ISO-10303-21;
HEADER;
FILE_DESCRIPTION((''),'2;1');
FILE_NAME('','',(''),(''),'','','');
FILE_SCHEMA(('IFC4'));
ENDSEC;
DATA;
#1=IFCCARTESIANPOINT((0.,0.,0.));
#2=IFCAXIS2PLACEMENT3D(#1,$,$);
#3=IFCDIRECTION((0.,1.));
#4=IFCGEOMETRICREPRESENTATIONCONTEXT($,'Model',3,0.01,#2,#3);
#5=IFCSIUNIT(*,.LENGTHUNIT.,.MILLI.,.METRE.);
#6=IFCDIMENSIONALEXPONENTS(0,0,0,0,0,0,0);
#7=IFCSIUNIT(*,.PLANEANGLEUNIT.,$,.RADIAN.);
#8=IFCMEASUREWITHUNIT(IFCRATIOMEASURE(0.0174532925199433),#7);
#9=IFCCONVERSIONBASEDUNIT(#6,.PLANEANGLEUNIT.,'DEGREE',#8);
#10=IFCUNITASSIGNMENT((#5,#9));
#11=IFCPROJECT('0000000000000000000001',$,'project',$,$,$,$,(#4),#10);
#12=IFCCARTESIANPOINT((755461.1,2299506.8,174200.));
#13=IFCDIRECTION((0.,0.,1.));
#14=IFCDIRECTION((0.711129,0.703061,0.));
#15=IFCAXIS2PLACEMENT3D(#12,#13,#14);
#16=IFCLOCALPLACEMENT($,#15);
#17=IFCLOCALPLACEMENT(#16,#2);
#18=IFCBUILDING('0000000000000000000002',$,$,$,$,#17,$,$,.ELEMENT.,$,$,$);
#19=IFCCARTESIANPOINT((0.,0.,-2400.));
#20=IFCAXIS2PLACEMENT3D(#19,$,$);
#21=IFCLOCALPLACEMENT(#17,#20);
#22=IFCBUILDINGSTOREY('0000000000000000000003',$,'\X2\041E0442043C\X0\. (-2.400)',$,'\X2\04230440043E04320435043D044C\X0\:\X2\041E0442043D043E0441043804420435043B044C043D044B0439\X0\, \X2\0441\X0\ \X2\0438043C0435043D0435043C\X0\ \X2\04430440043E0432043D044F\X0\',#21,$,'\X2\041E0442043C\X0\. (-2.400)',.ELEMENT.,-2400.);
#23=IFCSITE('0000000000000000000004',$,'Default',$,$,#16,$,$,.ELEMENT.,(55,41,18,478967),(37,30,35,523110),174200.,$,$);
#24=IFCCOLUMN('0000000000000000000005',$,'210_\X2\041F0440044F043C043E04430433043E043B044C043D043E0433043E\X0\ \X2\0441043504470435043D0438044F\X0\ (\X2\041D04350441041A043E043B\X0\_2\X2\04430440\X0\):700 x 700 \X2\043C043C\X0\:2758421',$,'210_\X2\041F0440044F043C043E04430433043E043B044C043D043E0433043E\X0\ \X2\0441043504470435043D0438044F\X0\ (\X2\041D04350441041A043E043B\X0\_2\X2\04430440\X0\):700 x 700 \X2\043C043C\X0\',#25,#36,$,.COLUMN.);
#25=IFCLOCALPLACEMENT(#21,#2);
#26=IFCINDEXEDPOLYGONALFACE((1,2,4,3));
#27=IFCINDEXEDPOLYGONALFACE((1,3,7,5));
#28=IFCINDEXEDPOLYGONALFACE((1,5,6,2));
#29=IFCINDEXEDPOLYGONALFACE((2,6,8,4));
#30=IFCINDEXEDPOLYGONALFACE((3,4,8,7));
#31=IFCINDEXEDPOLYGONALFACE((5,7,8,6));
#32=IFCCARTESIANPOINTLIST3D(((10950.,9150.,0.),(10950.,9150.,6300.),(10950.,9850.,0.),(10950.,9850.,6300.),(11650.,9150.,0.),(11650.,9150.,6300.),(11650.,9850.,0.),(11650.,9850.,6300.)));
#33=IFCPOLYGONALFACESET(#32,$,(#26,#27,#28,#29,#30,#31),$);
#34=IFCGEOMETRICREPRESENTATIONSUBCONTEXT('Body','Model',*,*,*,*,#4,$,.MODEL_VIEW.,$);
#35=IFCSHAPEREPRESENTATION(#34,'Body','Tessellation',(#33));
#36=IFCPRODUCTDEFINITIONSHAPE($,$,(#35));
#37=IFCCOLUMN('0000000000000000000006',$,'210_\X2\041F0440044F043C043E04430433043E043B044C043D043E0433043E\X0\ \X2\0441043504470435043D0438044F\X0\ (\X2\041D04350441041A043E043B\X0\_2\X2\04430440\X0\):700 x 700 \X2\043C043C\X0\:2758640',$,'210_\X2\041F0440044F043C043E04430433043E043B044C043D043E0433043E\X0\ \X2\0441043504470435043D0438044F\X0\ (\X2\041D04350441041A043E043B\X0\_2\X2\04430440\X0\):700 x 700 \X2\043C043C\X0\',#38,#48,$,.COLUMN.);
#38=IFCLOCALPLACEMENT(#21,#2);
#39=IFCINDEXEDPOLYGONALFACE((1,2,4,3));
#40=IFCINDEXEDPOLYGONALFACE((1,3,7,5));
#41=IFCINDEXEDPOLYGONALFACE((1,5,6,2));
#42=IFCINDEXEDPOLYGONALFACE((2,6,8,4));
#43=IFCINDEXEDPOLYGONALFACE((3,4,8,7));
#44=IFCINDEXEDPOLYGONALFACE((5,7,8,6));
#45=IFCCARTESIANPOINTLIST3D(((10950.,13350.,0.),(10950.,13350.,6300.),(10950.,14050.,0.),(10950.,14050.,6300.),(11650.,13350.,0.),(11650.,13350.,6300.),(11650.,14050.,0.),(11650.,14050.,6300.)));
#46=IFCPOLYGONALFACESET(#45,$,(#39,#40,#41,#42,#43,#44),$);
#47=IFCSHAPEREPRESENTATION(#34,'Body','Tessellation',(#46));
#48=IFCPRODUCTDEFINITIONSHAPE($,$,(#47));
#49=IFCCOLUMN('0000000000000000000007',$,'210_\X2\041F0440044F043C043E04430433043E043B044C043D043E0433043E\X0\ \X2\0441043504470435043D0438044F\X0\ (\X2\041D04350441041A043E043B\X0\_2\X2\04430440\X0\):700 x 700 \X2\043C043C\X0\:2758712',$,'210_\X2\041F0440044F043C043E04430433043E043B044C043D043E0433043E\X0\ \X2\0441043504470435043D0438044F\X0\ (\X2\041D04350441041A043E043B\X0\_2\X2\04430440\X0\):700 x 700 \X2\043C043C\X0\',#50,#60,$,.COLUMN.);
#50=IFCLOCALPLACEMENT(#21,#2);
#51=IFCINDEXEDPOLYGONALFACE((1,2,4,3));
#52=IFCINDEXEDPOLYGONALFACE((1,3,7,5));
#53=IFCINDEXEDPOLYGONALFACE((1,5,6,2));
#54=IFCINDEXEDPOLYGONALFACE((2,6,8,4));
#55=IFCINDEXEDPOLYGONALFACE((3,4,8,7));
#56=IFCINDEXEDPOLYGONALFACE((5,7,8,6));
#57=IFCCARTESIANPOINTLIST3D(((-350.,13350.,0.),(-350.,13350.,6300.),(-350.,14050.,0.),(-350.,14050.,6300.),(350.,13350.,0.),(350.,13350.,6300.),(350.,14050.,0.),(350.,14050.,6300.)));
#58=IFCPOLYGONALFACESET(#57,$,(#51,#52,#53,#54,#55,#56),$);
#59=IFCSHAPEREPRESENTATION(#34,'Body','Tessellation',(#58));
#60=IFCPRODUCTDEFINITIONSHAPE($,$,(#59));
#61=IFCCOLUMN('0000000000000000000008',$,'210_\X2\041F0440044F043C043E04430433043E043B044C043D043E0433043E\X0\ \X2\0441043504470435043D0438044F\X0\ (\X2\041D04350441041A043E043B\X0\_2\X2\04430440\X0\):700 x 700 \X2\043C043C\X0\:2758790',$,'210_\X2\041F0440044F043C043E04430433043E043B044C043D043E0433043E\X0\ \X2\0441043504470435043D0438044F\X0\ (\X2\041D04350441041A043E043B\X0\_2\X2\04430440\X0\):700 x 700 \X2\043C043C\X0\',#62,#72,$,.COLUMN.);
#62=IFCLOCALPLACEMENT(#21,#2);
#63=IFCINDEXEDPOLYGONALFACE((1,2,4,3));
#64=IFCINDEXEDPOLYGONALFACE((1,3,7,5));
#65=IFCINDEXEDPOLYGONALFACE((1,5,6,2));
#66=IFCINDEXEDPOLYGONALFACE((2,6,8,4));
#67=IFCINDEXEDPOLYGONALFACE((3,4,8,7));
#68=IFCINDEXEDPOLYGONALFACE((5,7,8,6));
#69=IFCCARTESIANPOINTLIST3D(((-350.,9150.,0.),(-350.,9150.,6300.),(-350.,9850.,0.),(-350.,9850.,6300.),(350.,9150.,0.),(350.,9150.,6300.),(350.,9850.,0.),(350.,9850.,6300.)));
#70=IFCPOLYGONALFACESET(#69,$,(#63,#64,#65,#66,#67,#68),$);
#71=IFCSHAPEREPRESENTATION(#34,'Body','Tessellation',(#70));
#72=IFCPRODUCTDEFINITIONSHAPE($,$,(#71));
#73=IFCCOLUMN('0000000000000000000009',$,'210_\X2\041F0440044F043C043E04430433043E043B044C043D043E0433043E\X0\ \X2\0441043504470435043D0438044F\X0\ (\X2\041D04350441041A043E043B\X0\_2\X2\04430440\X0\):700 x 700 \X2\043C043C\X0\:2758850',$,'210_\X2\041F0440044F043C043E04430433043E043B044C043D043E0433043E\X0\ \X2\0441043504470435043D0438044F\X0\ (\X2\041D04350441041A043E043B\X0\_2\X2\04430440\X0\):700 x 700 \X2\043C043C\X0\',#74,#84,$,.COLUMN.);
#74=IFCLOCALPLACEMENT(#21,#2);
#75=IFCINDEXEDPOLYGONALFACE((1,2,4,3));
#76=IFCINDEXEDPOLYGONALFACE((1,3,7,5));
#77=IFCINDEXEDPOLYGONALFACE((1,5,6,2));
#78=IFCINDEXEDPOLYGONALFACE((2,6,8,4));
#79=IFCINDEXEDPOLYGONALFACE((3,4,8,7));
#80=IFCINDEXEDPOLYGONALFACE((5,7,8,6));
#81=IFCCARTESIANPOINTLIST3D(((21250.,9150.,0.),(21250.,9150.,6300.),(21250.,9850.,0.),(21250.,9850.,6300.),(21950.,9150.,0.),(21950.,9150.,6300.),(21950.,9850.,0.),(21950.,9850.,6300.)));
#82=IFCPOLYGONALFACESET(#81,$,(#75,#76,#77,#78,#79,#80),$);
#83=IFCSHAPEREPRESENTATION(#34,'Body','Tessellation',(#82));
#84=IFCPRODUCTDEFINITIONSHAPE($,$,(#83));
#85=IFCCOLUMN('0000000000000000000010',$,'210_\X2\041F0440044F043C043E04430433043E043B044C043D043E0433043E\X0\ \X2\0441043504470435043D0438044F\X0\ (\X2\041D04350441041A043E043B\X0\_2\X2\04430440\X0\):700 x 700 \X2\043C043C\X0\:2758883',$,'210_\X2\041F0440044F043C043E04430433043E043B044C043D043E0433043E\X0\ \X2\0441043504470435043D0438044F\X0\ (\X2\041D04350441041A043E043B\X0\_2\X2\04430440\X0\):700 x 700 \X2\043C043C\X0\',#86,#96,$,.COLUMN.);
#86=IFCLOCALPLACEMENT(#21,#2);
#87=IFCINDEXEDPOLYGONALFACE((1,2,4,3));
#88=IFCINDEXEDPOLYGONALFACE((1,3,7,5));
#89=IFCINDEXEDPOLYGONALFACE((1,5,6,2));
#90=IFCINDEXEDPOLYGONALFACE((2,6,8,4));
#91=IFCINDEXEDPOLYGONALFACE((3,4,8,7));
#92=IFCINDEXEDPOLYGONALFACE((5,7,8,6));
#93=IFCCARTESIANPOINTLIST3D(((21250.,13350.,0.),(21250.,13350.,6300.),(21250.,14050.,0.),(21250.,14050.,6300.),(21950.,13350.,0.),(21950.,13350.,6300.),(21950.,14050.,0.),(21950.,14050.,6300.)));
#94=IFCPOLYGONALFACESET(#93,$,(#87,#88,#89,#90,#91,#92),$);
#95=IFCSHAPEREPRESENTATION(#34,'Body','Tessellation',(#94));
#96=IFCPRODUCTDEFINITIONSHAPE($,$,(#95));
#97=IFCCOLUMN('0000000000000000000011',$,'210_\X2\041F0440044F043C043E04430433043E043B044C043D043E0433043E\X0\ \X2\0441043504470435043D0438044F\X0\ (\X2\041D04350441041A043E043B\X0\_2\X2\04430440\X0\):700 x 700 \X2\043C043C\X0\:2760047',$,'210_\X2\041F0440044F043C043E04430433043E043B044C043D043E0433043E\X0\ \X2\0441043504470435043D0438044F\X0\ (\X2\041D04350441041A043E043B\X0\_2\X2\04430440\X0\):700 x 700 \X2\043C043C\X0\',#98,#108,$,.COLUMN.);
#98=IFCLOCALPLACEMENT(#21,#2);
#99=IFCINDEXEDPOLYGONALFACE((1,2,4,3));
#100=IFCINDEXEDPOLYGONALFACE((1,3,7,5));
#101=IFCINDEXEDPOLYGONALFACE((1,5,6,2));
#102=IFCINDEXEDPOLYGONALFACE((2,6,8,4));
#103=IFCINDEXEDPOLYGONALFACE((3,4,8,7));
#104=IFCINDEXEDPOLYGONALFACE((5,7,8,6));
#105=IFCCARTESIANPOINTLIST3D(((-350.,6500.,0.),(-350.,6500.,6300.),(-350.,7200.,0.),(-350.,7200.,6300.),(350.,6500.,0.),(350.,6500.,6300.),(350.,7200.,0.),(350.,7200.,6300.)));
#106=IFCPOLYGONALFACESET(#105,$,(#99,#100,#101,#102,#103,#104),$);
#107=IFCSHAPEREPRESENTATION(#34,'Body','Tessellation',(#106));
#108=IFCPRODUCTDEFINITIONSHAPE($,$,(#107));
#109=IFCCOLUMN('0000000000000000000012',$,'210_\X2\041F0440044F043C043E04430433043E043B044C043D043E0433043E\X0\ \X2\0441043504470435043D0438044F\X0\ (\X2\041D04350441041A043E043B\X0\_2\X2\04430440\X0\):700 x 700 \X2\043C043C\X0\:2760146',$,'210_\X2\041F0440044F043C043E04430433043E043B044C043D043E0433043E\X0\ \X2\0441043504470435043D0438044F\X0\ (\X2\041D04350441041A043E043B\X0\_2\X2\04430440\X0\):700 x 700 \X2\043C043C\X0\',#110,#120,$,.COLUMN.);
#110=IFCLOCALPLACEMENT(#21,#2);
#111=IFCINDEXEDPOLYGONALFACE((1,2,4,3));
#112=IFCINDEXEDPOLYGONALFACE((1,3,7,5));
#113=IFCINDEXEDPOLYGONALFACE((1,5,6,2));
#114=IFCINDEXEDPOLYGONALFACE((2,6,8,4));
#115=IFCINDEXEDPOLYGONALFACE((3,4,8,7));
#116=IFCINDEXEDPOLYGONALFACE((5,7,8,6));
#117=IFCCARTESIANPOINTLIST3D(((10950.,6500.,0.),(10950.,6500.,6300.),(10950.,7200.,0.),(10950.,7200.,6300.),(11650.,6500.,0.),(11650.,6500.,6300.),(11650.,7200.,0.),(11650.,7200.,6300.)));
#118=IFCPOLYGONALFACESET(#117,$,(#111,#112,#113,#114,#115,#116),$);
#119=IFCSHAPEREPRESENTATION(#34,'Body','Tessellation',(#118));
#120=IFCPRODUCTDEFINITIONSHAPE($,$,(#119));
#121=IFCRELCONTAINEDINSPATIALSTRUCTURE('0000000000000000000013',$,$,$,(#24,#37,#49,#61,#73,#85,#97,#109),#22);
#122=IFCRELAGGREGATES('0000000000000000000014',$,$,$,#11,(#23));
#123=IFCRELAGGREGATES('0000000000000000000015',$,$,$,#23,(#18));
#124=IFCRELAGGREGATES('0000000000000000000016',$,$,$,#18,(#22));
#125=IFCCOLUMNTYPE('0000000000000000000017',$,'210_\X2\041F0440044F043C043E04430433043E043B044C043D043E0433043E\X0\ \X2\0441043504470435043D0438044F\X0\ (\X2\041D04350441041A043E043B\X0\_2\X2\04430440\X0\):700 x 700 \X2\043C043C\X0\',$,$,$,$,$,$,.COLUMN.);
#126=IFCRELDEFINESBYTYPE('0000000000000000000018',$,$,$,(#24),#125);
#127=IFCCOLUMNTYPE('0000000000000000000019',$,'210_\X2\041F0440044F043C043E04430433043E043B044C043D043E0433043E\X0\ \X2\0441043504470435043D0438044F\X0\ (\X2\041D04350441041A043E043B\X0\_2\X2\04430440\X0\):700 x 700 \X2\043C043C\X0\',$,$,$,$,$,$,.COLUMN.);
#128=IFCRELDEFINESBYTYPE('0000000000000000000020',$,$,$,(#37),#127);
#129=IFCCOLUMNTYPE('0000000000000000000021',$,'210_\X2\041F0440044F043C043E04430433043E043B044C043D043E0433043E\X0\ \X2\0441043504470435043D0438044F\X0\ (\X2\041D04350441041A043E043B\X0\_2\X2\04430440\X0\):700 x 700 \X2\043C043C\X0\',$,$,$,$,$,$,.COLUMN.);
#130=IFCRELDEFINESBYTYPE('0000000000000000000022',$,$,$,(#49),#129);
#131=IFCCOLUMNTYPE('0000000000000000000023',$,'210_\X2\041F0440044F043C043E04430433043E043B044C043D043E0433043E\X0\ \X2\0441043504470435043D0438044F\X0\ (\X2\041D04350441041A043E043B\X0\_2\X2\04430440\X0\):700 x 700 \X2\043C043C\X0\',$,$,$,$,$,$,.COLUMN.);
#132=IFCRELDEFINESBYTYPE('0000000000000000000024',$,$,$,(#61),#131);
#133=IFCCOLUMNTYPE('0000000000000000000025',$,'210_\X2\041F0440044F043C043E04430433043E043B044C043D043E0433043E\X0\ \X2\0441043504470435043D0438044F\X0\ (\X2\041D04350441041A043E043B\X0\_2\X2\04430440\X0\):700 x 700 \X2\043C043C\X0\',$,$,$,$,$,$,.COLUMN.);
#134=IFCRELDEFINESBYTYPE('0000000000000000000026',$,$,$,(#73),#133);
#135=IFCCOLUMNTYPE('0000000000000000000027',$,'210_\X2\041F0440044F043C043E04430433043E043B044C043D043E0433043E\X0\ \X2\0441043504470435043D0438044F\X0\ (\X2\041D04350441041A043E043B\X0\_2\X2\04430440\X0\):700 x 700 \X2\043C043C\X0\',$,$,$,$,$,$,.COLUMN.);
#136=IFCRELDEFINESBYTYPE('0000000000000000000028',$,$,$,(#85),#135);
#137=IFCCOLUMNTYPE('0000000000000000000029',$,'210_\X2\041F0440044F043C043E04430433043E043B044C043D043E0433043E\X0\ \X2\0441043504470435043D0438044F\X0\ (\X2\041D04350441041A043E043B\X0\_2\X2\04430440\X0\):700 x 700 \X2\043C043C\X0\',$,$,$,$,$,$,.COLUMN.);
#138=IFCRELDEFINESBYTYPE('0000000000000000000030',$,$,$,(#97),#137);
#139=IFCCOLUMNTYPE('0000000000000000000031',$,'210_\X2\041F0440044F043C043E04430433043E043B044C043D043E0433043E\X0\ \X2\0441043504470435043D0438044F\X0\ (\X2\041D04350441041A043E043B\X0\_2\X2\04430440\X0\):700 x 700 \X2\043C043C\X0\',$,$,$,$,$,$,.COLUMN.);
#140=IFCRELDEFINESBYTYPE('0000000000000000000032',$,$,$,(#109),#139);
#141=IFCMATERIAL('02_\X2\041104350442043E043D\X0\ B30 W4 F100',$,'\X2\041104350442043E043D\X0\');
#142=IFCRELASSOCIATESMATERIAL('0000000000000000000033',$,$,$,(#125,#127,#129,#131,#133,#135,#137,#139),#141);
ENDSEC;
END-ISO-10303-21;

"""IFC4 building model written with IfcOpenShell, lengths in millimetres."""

from ifc_helpers import new_model, entity, si_unit, converted_unit, direction, frame, origin, place, context, subcontext, project, spatial, indexed_curve, outline, extrude, source, transform, mapped, material, type_object, type_shapes, element, save


model = new_model("IFC4")

# Units and contexts
model_context = context("Model", 3, precision=0.01, world=origin(), true_north=direction((0.0, 1.0)))
body_context = subcontext(model_context, "Body", "Model", "MODEL_VIEW")
ifc_project = project(units=[si_unit("LENGTHUNIT", "METRE", prefix="MILLI"), converted_unit("PLANEANGLEUNIT", "DEGREE", entity("IfcRatioMeasure", 0.0174532925199433), si_unit("PLANEANGLEUNIT", "RADIAN"), dimensions=[0, 0, 0, 0, 0, 0, 0])], contexts=[model_context])

# Site, building, storey
site_placement = place(None, frame((755461.1, 2299506.8, 174200.0), z_axis=(0.0, 0.0, 1.0), x_axis=(0.711129, 0.703061, 0.0)))
site = spatial("IfcSite", under=ifc_project, at=site_placement, Name="Default", CompositionType="ELEMENT", RefLatitude=(55, 41, 18, 478967), RefLongitude=(37, 30, 35, 523110), RefElevation=174200.0)
building_placement = place(site_placement, origin())
building = spatial("IfcBuilding", under=site, at=building_placement, CompositionType="ELEMENT")
storey_placement = place(building_placement, frame((0.0, 0.0, -2400.0)))
storey = spatial("IfcBuildingStorey", under=building, at=storey_placement, Name="Отм. (-2.400)", ObjectType="Уровень:Относительный, с именем уровня", LongName="Отм. (-2.400)", CompositionType="ELEMENT", Elevation=-2400.0)

# Columns
ifc_material_1 = material(Name="02_Бетон B30 W4 F100", Category="Бетон")
column_type_1 = type_object("IfcColumnType", Name="210_Прямоугольного сечения (НесКол_2ур):700 x 700 мм", PredefinedType="COLUMN", material=ifc_material_1)
shared_shape_1 = source(origin(), body_context, "Body", "SweptSolid", [
    extrude(outline(indexed_curve([(-350.0, -350.0), (350.0, -350.0), (350.0, 350.0), (-350.0, 350.0), (-350.0, -350.0)], self_intersect=False)), frame((11300.0, 9500.0, -2400.0), z_axis=(0.0, 0.0, 1.0), x_axis=(0.0, -1.0, 0.0)), (0.0, 0.0, 1.0), 6300.0),
])
type_shapes(column_type_1, [shared_shape_1])
column_1_placement = place(storey_placement, frame((0.0, 0.0, 2400.0)))
element("IfcColumn", 1, at=column_1_placement, inside=storey, type_object=column_type_1, Name="210_Прямоугольного сечения (НесКол_2ур):700 x 700 мм:2758421", ObjectType="210_Прямоугольного сечения (НесКол_2ур):700 x 700 мм", PredefinedType="COLUMN", context=body_context, shape_type="MappedRepresentation", body=[
    mapped(shared_shape_1, transform((0.0, 0.0, 0.0), scale=1.0)),
])
column_type_2 = type_object("IfcColumnType", Name="210_Прямоугольного сечения (НесКол_2ур):700 x 700 мм", PredefinedType="COLUMN", material=ifc_material_1)
shared_shape_2 = source(origin(), body_context, "Body", "SweptSolid", [
    extrude(outline(indexed_curve([(-350.0, -350.0), (350.0, -350.0), (350.0, 350.0), (-350.0, 350.0), (-350.0, -350.0)], self_intersect=False)), frame((11300.0, 13700.0, -2400.0), z_axis=(0.0, 0.0, 1.0), x_axis=(0.0, -1.0, 0.0)), (0.0, 0.0, 1.0), 6300.0),
])
type_shapes(column_type_2, [shared_shape_2])
column_2_placement = place(storey_placement, frame((0.0, 0.0, 2400.0)))
element("IfcColumn", 2, at=column_2_placement, inside=storey, type_object=column_type_2, Name="210_Прямоугольного сечения (НесКол_2ур):700 x 700 мм:2758640", ObjectType="210_Прямоугольного сечения (НесКол_2ур):700 x 700 мм", PredefinedType="COLUMN", context=body_context, shape_type="MappedRepresentation", body=[
    mapped(shared_shape_2, transform((0.0, 0.0, 0.0), scale=1.0)),
])
column_type_3 = type_object("IfcColumnType", Name="210_Прямоугольного сечения (НесКол_2ур):700 x 700 мм", PredefinedType="COLUMN", material=ifc_material_1)
shared_shape_3 = source(origin(), body_context, "Body", "SweptSolid", [
    extrude(outline(indexed_curve([(-350.0, -350.0), (350.0, -350.0), (350.0, 350.0), (-350.0, 350.0), (-350.0, -350.0)], self_intersect=False)), frame((0.0, 13700.0, -2400.0), z_axis=(0.0, 0.0, 1.0), x_axis=(0.0, -1.0, 0.0)), (0.0, 0.0, 1.0), 6300.0),
])
type_shapes(column_type_3, [shared_shape_3])
column_3_placement = place(storey_placement, frame((0.0, 0.0, 2400.0)))
element("IfcColumn", 3, at=column_3_placement, inside=storey, type_object=column_type_3, Name="210_Прямоугольного сечения (НесКол_2ур):700 x 700 мм:2758712", ObjectType="210_Прямоугольного сечения (НесКол_2ур):700 x 700 мм", PredefinedType="COLUMN", context=body_context, shape_type="MappedRepresentation", body=[
    mapped(shared_shape_3, transform((0.0, 0.0, 0.0), scale=1.0)),
])
column_type_4 = type_object("IfcColumnType", Name="210_Прямоугольного сечения (НесКол_2ур):700 x 700 мм", PredefinedType="COLUMN", material=ifc_material_1)
shared_shape_4 = source(origin(), body_context, "Body", "SweptSolid", [
    extrude(outline(indexed_curve([(-350.0, -350.0), (350.0, -350.0), (350.0, 350.0), (-350.0, 350.0), (-350.0, -350.0)], self_intersect=False)), frame((0.0, 9500.0, -2400.0), z_axis=(0.0, 0.0, 1.0), x_axis=(0.0, -1.0, 0.0)), (0.0, 0.0, 1.0), 6300.0),
])
type_shapes(column_type_4, [shared_shape_4])
column_4_placement = place(storey_placement, frame((0.0, 0.0, 2400.0)))
element("IfcColumn", 4, at=column_4_placement, inside=storey, type_object=column_type_4, Name="210_Прямоугольного сечения (НесКол_2ур):700 x 700 мм:2758790", ObjectType="210_Прямоугольного сечения (НесКол_2ур):700 x 700 мм", PredefinedType="COLUMN", context=body_context, shape_type="MappedRepresentation", body=[
    mapped(shared_shape_4, transform((0.0, 0.0, 0.0), scale=1.0)),
])
column_type_5 = type_object("IfcColumnType", Name="210_Прямоугольного сечения (НесКол_2ур):700 x 700 мм", PredefinedType="COLUMN", material=ifc_material_1)
shared_shape_5 = source(origin(), body_context, "Body", "SweptSolid", [
    extrude(outline(indexed_curve([(-350.0, -350.0), (350.0, -350.0), (350.0, 350.0), (-350.0, 350.0), (-350.0, -350.0)], self_intersect=False)), frame((21600.0, 9500.0, -2400.0), z_axis=(0.0, 0.0, 1.0), x_axis=(0.0, -1.0, 0.0)), (0.0, 0.0, 1.0), 6300.0),
])
type_shapes(column_type_5, [shared_shape_5])
column_5_placement = place(storey_placement, frame((0.0, 0.0, 2400.0)))
element("IfcColumn", 5, at=column_5_placement, inside=storey, type_object=column_type_5, Name="210_Прямоугольного сечения (НесКол_2ур):700 x 700 мм:2758850", ObjectType="210_Прямоугольного сечения (НесКол_2ур):700 x 700 мм", PredefinedType="COLUMN", context=body_context, shape_type="MappedRepresentation", body=[
    mapped(shared_shape_5, transform((0.0, 0.0, 0.0), scale=1.0)),
])
column_type_6 = type_object("IfcColumnType", Name="210_Прямоугольного сечения (НесКол_2ур):700 x 700 мм", PredefinedType="COLUMN", material=ifc_material_1)
shared_shape_6 = source(origin(), body_context, "Body", "SweptSolid", [
    extrude(outline(indexed_curve([(-350.0, -350.0), (350.0, -350.0), (350.0, 350.0), (-350.0, 350.0), (-350.0, -350.0)], self_intersect=False)), frame((21600.0, 13700.0, -2400.0), z_axis=(0.0, 0.0, 1.0), x_axis=(0.0, -1.0, 0.0)), (0.0, 0.0, 1.0), 6300.0),
])
type_shapes(column_type_6, [shared_shape_6])
column_6_placement = place(storey_placement, frame((0.0, 0.0, 2400.0)))
element("IfcColumn", 6, at=column_6_placement, inside=storey, type_object=column_type_6, Name="210_Прямоугольного сечения (НесКол_2ур):700 x 700 мм:2758883", ObjectType="210_Прямоугольного сечения (НесКол_2ур):700 x 700 мм", PredefinedType="COLUMN", context=body_context, shape_type="MappedRepresentation", body=[
    mapped(shared_shape_6, transform((0.0, 0.0, 0.0), scale=1.0)),
])
column_type_7 = type_object("IfcColumnType", Name="210_Прямоугольного сечения (НесКол_2ур):700 x 700 мм", PredefinedType="COLUMN", material=ifc_material_1)
shared_shape_7 = source(origin(), body_context, "Body", "SweptSolid", [
    extrude(outline(indexed_curve([(-350.0, -350.0), (350.0, -350.0), (350.0, 350.0), (-350.0, 350.0), (-350.0, -350.0)], self_intersect=False)), frame((0.0, 6850.0, -2400.0), z_axis=(0.0, 0.0, 1.0), x_axis=(0.0, -1.0, 0.0)), (0.0, 0.0, 1.0), 6300.0),
])
type_shapes(column_type_7, [shared_shape_7])
column_7_placement = place(storey_placement, frame((0.0, 0.0, 2400.0)))
element("IfcColumn", 7, at=column_7_placement, inside=storey, type_object=column_type_7, Name="210_Прямоугольного сечения (НесКол_2ур):700 x 700 мм:2760047", ObjectType="210_Прямоугольного сечения (НесКол_2ур):700 x 700 мм", PredefinedType="COLUMN", context=body_context, shape_type="MappedRepresentation", body=[
    mapped(shared_shape_7, transform((0.0, 0.0, 0.0), scale=1.0)),
])
column_type_8 = type_object("IfcColumnType", Name="210_Прямоугольного сечения (НесКол_2ур):700 x 700 мм", PredefinedType="COLUMN", material=ifc_material_1)
shared_shape_8 = source(origin(), body_context, "Body", "SweptSolid", [
    extrude(outline(indexed_curve([(-350.0, -350.0), (350.0, -350.0), (350.0, 350.0), (-350.0, 350.0), (-350.0, -350.0)], self_intersect=False)), frame((11300.0, 6850.0, -2400.0), z_axis=(0.0, 0.0, 1.0), x_axis=(0.0, -1.0, 0.0)), (0.0, 0.0, 1.0), 6300.0),
])
type_shapes(column_type_8, [shared_shape_8])
column_8_placement = place(storey_placement, frame((0.0, 0.0, 2400.0)))
element("IfcColumn", 8, at=column_8_placement, inside=storey, type_object=column_type_8, Name="210_Прямоугольного сечения (НесКол_2ур):700 x 700 мм:2760146", ObjectType="210_Прямоугольного сечения (НесКол_2ур):700 x 700 мм", PredefinedType="COLUMN", context=body_context, shape_type="MappedRepresentation", body=[
    mapped(shared_shape_8, transform((0.0, 0.0, 0.0), scale=1.0)),
])

save(model, "model.ifc")
